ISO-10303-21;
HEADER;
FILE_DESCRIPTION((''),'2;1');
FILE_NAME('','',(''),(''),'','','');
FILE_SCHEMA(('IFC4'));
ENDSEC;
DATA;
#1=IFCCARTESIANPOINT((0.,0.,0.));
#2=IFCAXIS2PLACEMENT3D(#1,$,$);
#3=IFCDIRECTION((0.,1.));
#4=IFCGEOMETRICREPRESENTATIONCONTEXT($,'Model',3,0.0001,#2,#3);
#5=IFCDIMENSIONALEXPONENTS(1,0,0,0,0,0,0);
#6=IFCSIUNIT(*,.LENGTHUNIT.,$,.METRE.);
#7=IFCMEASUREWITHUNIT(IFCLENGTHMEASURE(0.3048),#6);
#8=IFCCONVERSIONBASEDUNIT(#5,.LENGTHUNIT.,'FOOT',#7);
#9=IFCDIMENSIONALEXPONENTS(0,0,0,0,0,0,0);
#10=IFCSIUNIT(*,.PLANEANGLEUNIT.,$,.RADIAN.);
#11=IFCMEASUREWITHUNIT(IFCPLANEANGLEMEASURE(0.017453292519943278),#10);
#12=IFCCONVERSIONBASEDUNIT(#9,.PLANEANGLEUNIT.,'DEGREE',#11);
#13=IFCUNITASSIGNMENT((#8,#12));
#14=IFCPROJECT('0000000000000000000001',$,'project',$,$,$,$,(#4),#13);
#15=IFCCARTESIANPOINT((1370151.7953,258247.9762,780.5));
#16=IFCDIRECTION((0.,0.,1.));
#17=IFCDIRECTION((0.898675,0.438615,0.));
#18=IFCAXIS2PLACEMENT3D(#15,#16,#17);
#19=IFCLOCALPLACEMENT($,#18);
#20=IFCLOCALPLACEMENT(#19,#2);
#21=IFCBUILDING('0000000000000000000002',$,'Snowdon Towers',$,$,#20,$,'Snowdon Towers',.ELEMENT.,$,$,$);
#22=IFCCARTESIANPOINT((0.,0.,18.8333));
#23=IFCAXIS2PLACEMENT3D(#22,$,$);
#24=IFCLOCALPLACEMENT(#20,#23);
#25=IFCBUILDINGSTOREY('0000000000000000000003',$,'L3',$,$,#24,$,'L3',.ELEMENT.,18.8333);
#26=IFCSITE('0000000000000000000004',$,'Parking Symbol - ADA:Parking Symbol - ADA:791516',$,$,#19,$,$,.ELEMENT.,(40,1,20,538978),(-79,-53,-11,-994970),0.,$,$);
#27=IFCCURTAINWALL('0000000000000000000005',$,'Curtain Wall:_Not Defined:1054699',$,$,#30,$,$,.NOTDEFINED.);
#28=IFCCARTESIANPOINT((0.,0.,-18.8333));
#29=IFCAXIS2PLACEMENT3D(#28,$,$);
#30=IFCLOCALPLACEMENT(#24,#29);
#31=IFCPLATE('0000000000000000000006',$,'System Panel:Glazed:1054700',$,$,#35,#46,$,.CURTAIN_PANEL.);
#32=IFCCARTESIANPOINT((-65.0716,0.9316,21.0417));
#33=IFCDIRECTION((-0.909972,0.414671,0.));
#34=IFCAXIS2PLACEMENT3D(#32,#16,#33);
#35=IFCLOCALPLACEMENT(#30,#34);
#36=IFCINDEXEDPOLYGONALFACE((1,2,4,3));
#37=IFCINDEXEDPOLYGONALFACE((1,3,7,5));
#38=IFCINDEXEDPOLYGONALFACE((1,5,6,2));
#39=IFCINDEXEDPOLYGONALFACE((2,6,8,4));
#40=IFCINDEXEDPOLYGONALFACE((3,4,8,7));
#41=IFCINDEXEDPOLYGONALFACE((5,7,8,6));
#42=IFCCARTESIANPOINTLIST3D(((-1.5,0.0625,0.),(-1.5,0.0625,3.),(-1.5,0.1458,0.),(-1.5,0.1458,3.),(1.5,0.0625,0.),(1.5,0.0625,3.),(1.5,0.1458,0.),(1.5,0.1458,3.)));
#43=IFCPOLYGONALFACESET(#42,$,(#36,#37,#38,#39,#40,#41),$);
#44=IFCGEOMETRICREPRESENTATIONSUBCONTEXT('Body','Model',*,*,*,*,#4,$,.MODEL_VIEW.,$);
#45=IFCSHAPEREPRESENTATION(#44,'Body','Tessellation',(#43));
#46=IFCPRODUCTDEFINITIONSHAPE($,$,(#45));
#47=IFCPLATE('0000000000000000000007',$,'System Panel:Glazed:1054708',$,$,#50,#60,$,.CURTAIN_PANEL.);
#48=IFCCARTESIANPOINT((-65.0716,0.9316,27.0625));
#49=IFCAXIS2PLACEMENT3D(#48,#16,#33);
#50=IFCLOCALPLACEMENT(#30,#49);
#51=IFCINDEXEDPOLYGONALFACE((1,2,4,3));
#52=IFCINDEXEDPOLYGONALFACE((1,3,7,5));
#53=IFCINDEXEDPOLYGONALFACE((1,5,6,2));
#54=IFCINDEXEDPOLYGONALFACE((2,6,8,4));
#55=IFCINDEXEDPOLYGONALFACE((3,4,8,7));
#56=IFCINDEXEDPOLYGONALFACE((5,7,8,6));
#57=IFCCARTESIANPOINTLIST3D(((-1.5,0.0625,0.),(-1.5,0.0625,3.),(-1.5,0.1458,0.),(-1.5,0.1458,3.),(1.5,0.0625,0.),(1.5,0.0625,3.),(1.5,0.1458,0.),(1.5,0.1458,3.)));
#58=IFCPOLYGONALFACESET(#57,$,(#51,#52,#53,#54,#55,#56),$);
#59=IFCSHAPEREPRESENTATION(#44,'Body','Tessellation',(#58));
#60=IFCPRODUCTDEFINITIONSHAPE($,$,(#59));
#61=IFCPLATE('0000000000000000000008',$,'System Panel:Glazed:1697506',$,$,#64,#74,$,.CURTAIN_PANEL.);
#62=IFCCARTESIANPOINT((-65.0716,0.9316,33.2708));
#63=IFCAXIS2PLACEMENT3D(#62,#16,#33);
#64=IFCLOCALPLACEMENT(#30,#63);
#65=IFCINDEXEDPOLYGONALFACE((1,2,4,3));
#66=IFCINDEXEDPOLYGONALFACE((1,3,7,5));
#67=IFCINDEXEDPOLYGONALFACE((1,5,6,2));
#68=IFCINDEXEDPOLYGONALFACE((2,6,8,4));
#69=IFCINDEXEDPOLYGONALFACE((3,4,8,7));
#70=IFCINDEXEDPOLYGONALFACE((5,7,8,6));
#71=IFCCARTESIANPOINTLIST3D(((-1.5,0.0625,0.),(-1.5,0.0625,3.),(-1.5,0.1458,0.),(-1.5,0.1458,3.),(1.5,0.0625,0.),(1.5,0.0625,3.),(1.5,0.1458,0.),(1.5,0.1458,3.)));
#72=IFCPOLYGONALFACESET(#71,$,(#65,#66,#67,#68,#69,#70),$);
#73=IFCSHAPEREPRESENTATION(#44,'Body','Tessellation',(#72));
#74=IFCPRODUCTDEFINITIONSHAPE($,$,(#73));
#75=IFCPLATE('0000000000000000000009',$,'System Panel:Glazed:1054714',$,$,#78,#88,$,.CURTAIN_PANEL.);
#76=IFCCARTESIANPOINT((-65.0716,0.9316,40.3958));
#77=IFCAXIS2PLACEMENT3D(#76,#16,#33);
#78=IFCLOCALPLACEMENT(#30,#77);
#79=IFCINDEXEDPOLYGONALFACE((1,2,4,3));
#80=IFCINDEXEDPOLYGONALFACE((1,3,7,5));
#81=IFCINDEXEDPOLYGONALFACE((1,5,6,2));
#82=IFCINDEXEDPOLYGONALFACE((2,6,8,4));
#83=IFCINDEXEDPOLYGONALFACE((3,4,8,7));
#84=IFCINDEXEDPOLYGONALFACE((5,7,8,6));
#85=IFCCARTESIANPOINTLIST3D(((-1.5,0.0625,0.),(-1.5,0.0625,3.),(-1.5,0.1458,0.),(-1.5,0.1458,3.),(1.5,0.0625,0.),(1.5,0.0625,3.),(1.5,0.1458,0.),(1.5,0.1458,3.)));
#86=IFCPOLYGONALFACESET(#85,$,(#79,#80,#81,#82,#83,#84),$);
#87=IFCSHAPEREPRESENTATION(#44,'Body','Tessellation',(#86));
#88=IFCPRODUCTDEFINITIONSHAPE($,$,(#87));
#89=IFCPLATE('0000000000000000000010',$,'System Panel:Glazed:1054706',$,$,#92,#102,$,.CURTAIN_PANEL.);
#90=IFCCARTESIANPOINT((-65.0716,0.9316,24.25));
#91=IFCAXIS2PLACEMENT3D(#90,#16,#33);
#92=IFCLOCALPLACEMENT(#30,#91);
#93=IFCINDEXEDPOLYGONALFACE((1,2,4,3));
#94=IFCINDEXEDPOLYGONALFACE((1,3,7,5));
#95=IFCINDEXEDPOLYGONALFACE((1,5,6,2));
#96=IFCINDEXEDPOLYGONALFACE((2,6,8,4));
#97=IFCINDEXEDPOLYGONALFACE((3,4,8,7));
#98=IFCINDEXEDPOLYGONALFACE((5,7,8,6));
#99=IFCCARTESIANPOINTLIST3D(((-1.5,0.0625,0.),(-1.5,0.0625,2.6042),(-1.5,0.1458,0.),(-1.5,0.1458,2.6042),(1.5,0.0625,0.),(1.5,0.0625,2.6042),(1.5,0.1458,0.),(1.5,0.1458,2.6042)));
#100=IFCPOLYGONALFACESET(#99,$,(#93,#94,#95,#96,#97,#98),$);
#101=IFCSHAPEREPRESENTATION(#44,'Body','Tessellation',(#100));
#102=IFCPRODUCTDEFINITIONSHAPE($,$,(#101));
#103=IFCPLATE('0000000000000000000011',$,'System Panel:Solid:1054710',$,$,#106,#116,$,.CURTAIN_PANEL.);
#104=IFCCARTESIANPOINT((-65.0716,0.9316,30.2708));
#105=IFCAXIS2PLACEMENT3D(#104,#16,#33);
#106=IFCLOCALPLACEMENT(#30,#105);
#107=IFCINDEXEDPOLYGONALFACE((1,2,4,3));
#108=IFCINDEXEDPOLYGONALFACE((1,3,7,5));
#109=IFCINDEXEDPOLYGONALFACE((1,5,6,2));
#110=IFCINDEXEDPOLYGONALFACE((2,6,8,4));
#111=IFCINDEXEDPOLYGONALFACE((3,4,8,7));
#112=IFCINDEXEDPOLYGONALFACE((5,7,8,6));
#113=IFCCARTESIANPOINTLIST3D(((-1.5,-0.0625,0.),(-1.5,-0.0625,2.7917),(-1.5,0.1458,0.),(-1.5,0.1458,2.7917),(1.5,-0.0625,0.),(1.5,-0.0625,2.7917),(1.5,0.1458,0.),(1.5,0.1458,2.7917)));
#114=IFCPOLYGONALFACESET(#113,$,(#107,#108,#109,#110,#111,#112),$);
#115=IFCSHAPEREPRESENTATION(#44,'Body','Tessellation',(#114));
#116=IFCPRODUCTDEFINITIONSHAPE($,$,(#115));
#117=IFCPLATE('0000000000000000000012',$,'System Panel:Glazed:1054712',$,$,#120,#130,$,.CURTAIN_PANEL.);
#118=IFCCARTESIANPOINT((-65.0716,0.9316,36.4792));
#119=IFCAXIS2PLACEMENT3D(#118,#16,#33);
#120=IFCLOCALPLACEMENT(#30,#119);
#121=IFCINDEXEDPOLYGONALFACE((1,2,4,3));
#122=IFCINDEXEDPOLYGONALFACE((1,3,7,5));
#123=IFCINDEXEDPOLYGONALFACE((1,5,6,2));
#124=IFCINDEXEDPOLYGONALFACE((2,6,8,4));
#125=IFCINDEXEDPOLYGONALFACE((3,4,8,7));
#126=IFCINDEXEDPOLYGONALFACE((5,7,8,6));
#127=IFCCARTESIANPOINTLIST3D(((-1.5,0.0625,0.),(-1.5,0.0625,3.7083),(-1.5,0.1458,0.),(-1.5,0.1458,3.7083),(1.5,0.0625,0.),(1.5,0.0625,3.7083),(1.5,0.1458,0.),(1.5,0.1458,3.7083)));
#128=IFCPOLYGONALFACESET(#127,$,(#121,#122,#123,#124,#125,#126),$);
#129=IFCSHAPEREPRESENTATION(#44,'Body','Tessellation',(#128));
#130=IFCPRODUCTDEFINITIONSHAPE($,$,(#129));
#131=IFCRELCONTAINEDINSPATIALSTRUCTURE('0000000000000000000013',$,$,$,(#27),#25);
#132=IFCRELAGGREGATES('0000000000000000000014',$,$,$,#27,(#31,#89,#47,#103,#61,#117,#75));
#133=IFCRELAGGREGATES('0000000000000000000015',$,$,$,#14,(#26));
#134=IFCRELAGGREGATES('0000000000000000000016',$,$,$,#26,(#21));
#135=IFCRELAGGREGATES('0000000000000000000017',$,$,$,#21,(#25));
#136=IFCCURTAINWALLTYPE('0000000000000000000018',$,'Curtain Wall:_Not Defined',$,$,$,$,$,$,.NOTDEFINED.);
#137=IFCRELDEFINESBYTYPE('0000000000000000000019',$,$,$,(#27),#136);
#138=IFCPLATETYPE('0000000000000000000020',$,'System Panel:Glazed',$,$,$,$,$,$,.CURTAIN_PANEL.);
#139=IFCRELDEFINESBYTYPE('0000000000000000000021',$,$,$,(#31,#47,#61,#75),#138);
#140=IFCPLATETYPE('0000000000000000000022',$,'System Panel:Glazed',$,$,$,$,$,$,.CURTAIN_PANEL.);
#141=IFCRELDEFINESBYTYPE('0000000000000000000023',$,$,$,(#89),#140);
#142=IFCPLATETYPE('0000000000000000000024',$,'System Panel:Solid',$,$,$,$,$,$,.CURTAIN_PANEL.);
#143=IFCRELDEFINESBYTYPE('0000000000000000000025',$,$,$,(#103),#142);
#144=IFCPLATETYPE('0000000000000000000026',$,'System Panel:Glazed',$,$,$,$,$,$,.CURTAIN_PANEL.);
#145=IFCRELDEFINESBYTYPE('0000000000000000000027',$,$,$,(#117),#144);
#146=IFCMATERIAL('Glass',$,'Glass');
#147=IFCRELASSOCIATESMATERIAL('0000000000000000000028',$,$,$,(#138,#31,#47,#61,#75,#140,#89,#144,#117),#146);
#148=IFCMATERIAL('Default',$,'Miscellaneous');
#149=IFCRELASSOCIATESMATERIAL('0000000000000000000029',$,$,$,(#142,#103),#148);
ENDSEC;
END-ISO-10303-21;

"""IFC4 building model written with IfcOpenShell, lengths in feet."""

from ifc_helpers import new_model, entity, si_unit, converted_unit, direction, frame, origin, place, context, subcontext, project, spatial, indexed_curve, outline, extrude, source, transform, mapped, material, type_object, type_shapes, element, aggregate, save


model = new_model("IFC4")

# Units and contexts
model_context = context("Model", 3, precision=0.0001, world=origin(), true_north=direction((0.0, 1.0)))
body_context = subcontext(model_context, "Body", "Model", "MODEL_VIEW")
ifc_project = project(units=[converted_unit("LENGTHUNIT", "FOOT", entity("IfcLengthMeasure", 0.3048), si_unit("LENGTHUNIT", "METRE"), dimensions=[1, 0, 0, 0, 0, 0, 0]), converted_unit("PLANEANGLEUNIT", "DEGREE", entity("IfcPlaneAngleMeasure", 0.017453292519943278), si_unit("PLANEANGLEUNIT", "RADIAN"), dimensions=[0, 0, 0, 0, 0, 0, 0])], contexts=[model_context])

# Site, building, storey
site_placement = place(None, frame((1370151.7953, 258247.9762, 780.5), z_axis=(0.0, 0.0, 1.0), x_axis=(0.898675, 0.438615, 0.0)))
site = spatial("IfcSite", under=ifc_project, at=site_placement, Name="Parking Symbol - ADA:Parking Symbol - ADA:791516", CompositionType="ELEMENT", RefLatitude=(40, 1, 20, 538978), RefLongitude=(-79, -53, -11, -994970), RefElevation=0.0)
building_placement = place(site_placement, origin())
building = spatial("IfcBuilding", under=site, at=building_placement, Name="Snowdon Towers", LongName="Snowdon Towers", CompositionType="ELEMENT")
storey_placement = place(building_placement, frame((0.0, 0.0, 18.8333)))
storey = spatial("IfcBuildingStorey", under=building, at=storey_placement, Name="L3", LongName="L3", CompositionType="ELEMENT", Elevation=18.8333)

# Curtain wall
curtain_wall_type_1 = type_object("IfcCurtainWallType", Name="Curtain Wall:_Not Defined", PredefinedType="NOTDEFINED")
curtain_wall_1_placement = place(storey_placement, frame((0.0, 0.0, -18.8333)))
curtain_wall_1 = element("IfcCurtainWall", 1, at=curtain_wall_1_placement, inside=storey, type_object=curtain_wall_type_1, Name="Curtain Wall:_Not Defined:1054699", PredefinedType="NOTDEFINED")

# Plates
ifc_material_1 = material(Name="Glass", Category="Glass")
plate_type_1 = type_object("IfcPlateType", Name="System Panel:Glazed", PredefinedType="CURTAIN_PANEL", material=ifc_material_1)
shared_shape_1 = source(origin(), body_context, "Body", "SweptSolid", [
    extrude(outline(indexed_curve([(-0.0417, -1.5), (0.0417, -1.5), (0.0417, 1.5), (-0.0417, 1.5), (-0.0417, -1.5)], self_intersect=False)), frame((0.0, 0.1042, 0.0), z_axis=(0.0, 0.0, 1.0), x_axis=(0.0, 1.0, 0.0)), (0.0, 0.0, 1.0), 3.0),
])
type_shapes(plate_type_1, [shared_shape_1])
plate_1_placement = place(curtain_wall_1_placement, frame((-65.0716, 0.9316, 21.0417), z_axis=(0.0, 0.0, 1.0), x_axis=(-0.909972, 0.414671, 0.0)))
plate_1 = element("IfcPlate", 2, at=plate_1_placement, type_object=plate_type_1, material=ifc_material_1, Name="System Panel:Glazed:1054700", PredefinedType="CURTAIN_PANEL", context=body_context, shape_type="MappedRepresentation", body=[
    mapped(shared_shape_1, transform((0.0, 0.0, 0.0), scale=1.0)),
])
plate_2_placement = place(curtain_wall_1_placement, frame((-65.0716, 0.9316, 27.0625), z_axis=(0.0, 0.0, 1.0), x_axis=(-0.909972, 0.414671, 0.0)))
plate_2 = element("IfcPlate", 3, at=plate_2_placement, type_object=plate_type_1, material=ifc_material_1, Name="System Panel:Glazed:1054708", PredefinedType="CURTAIN_PANEL", context=body_context, shape_type="MappedRepresentation", body=[
    mapped(shared_shape_1, transform((0.0, 0.0, 0.0), scale=1.0)),
])
plate_3_placement = place(curtain_wall_1_placement, frame((-65.0716, 0.9316, 33.2708), z_axis=(0.0, 0.0, 1.0), x_axis=(-0.909972, 0.414671, 0.0)))
plate_3 = element("IfcPlate", 4, at=plate_3_placement, type_object=plate_type_1, material=ifc_material_1, Name="System Panel:Glazed:1697506", PredefinedType="CURTAIN_PANEL", context=body_context, shape_type="MappedRepresentation", body=[
    mapped(shared_shape_1, transform((0.0, 0.0, 0.0), scale=1.0)),
])
plate_4_placement = place(curtain_wall_1_placement, frame((-65.0716, 0.9316, 40.3958), z_axis=(0.0, 0.0, 1.0), x_axis=(-0.909972, 0.414671, 0.0)))
plate_4 = element("IfcPlate", 5, at=plate_4_placement, type_object=plate_type_1, material=ifc_material_1, Name="System Panel:Glazed:1054714", PredefinedType="CURTAIN_PANEL", context=body_context, shape_type="MappedRepresentation", body=[
    mapped(shared_shape_1, transform((0.0, 0.0, 0.0), scale=1.0)),
])
plate_type_2 = type_object("IfcPlateType", Name="System Panel:Glazed", PredefinedType="CURTAIN_PANEL", material=ifc_material_1)
shared_shape_2 = source(origin(), body_context, "Body", "SweptSolid", [
    extrude(outline(indexed_curve([(-0.0417, -1.5), (0.0417, -1.5), (0.0417, 1.5), (-0.0417, 1.5), (-0.0417, -1.5)], self_intersect=False)), frame((0.0, 0.1042, 0.0), z_axis=(0.0, 0.0, 1.0), x_axis=(0.0, 1.0, 0.0)), (0.0, 0.0, 1.0), 2.6042),
])
type_shapes(plate_type_2, [shared_shape_2])
plate_5_placement = place(curtain_wall_1_placement, frame((-65.0716, 0.9316, 24.25), z_axis=(0.0, 0.0, 1.0), x_axis=(-0.909972, 0.414671, 0.0)))
plate_5 = element("IfcPlate", 6, at=plate_5_placement, type_object=plate_type_2, material=ifc_material_1, Name="System Panel:Glazed:1054706", PredefinedType="CURTAIN_PANEL", context=body_context, shape_type="MappedRepresentation", body=[
    mapped(shared_shape_2, transform((0.0, 0.0, 0.0), scale=1.0)),
])
ifc_material_2 = material(Name="Default", Category="Miscellaneous")
plate_type_3 = type_object("IfcPlateType", Name="System Panel:Solid", PredefinedType="CURTAIN_PANEL", material=ifc_material_2)
shared_shape_3 = source(origin(), body_context, "Body", "SweptSolid", [
    extrude(outline(indexed_curve([(-0.1042, -1.5), (0.1042, -1.5), (0.1042, 1.5), (-0.1042, 1.5), (-0.1042, -1.5)], self_intersect=False)), frame((0.0, 0.0417, 0.0), z_axis=(0.0, 0.0, 1.0), x_axis=(0.0, 1.0, 0.0)), (0.0, 0.0, 1.0), 2.7917),
])
type_shapes(plate_type_3, [shared_shape_3])
plate_6_placement = place(curtain_wall_1_placement, frame((-65.0716, 0.9316, 30.2708), z_axis=(0.0, 0.0, 1.0), x_axis=(-0.909972, 0.414671, 0.0)))
plate_6 = element("IfcPlate", 7, at=plate_6_placement, type_object=plate_type_3, material=ifc_material_2, Name="System Panel:Solid:1054710", PredefinedType="CURTAIN_PANEL", context=body_context, shape_type="MappedRepresentation", body=[
    mapped(shared_shape_3, transform((0.0, 0.0, 0.0), scale=1.0)),
])
plate_type_4 = type_object("IfcPlateType", Name="System Panel:Glazed", PredefinedType="CURTAIN_PANEL", material=ifc_material_1)
shared_shape_4 = source(origin(), body_context, "Body", "SweptSolid", [
    extrude(outline(indexed_curve([(-0.0417, -1.5), (0.0417, -1.5), (0.0417, 1.5), (-0.0417, 1.5), (-0.0417, -1.5)], self_intersect=False)), frame((0.0, 0.1042, 0.0), z_axis=(0.0, 0.0, 1.0), x_axis=(0.0, 1.0, 0.0)), (0.0, 0.0, 1.0), 3.7083),
])
type_shapes(plate_type_4, [shared_shape_4])
plate_7_placement = place(curtain_wall_1_placement, frame((-65.0716, 0.9316, 36.4792), z_axis=(0.0, 0.0, 1.0), x_axis=(-0.909972, 0.414671, 0.0)))
plate_7 = element("IfcPlate", 8, at=plate_7_placement, type_object=plate_type_4, material=ifc_material_1, Name="System Panel:Glazed:1054712", PredefinedType="CURTAIN_PANEL", context=body_context, shape_type="MappedRepresentation", body=[
    mapped(shared_shape_4, transform((0.0, 0.0, 0.0), scale=1.0)),
])
aggregate(curtain_wall_1, [plate_1, plate_5, plate_2, plate_6, plate_3, plate_7, plate_4])

save(model, "model.ifc")
